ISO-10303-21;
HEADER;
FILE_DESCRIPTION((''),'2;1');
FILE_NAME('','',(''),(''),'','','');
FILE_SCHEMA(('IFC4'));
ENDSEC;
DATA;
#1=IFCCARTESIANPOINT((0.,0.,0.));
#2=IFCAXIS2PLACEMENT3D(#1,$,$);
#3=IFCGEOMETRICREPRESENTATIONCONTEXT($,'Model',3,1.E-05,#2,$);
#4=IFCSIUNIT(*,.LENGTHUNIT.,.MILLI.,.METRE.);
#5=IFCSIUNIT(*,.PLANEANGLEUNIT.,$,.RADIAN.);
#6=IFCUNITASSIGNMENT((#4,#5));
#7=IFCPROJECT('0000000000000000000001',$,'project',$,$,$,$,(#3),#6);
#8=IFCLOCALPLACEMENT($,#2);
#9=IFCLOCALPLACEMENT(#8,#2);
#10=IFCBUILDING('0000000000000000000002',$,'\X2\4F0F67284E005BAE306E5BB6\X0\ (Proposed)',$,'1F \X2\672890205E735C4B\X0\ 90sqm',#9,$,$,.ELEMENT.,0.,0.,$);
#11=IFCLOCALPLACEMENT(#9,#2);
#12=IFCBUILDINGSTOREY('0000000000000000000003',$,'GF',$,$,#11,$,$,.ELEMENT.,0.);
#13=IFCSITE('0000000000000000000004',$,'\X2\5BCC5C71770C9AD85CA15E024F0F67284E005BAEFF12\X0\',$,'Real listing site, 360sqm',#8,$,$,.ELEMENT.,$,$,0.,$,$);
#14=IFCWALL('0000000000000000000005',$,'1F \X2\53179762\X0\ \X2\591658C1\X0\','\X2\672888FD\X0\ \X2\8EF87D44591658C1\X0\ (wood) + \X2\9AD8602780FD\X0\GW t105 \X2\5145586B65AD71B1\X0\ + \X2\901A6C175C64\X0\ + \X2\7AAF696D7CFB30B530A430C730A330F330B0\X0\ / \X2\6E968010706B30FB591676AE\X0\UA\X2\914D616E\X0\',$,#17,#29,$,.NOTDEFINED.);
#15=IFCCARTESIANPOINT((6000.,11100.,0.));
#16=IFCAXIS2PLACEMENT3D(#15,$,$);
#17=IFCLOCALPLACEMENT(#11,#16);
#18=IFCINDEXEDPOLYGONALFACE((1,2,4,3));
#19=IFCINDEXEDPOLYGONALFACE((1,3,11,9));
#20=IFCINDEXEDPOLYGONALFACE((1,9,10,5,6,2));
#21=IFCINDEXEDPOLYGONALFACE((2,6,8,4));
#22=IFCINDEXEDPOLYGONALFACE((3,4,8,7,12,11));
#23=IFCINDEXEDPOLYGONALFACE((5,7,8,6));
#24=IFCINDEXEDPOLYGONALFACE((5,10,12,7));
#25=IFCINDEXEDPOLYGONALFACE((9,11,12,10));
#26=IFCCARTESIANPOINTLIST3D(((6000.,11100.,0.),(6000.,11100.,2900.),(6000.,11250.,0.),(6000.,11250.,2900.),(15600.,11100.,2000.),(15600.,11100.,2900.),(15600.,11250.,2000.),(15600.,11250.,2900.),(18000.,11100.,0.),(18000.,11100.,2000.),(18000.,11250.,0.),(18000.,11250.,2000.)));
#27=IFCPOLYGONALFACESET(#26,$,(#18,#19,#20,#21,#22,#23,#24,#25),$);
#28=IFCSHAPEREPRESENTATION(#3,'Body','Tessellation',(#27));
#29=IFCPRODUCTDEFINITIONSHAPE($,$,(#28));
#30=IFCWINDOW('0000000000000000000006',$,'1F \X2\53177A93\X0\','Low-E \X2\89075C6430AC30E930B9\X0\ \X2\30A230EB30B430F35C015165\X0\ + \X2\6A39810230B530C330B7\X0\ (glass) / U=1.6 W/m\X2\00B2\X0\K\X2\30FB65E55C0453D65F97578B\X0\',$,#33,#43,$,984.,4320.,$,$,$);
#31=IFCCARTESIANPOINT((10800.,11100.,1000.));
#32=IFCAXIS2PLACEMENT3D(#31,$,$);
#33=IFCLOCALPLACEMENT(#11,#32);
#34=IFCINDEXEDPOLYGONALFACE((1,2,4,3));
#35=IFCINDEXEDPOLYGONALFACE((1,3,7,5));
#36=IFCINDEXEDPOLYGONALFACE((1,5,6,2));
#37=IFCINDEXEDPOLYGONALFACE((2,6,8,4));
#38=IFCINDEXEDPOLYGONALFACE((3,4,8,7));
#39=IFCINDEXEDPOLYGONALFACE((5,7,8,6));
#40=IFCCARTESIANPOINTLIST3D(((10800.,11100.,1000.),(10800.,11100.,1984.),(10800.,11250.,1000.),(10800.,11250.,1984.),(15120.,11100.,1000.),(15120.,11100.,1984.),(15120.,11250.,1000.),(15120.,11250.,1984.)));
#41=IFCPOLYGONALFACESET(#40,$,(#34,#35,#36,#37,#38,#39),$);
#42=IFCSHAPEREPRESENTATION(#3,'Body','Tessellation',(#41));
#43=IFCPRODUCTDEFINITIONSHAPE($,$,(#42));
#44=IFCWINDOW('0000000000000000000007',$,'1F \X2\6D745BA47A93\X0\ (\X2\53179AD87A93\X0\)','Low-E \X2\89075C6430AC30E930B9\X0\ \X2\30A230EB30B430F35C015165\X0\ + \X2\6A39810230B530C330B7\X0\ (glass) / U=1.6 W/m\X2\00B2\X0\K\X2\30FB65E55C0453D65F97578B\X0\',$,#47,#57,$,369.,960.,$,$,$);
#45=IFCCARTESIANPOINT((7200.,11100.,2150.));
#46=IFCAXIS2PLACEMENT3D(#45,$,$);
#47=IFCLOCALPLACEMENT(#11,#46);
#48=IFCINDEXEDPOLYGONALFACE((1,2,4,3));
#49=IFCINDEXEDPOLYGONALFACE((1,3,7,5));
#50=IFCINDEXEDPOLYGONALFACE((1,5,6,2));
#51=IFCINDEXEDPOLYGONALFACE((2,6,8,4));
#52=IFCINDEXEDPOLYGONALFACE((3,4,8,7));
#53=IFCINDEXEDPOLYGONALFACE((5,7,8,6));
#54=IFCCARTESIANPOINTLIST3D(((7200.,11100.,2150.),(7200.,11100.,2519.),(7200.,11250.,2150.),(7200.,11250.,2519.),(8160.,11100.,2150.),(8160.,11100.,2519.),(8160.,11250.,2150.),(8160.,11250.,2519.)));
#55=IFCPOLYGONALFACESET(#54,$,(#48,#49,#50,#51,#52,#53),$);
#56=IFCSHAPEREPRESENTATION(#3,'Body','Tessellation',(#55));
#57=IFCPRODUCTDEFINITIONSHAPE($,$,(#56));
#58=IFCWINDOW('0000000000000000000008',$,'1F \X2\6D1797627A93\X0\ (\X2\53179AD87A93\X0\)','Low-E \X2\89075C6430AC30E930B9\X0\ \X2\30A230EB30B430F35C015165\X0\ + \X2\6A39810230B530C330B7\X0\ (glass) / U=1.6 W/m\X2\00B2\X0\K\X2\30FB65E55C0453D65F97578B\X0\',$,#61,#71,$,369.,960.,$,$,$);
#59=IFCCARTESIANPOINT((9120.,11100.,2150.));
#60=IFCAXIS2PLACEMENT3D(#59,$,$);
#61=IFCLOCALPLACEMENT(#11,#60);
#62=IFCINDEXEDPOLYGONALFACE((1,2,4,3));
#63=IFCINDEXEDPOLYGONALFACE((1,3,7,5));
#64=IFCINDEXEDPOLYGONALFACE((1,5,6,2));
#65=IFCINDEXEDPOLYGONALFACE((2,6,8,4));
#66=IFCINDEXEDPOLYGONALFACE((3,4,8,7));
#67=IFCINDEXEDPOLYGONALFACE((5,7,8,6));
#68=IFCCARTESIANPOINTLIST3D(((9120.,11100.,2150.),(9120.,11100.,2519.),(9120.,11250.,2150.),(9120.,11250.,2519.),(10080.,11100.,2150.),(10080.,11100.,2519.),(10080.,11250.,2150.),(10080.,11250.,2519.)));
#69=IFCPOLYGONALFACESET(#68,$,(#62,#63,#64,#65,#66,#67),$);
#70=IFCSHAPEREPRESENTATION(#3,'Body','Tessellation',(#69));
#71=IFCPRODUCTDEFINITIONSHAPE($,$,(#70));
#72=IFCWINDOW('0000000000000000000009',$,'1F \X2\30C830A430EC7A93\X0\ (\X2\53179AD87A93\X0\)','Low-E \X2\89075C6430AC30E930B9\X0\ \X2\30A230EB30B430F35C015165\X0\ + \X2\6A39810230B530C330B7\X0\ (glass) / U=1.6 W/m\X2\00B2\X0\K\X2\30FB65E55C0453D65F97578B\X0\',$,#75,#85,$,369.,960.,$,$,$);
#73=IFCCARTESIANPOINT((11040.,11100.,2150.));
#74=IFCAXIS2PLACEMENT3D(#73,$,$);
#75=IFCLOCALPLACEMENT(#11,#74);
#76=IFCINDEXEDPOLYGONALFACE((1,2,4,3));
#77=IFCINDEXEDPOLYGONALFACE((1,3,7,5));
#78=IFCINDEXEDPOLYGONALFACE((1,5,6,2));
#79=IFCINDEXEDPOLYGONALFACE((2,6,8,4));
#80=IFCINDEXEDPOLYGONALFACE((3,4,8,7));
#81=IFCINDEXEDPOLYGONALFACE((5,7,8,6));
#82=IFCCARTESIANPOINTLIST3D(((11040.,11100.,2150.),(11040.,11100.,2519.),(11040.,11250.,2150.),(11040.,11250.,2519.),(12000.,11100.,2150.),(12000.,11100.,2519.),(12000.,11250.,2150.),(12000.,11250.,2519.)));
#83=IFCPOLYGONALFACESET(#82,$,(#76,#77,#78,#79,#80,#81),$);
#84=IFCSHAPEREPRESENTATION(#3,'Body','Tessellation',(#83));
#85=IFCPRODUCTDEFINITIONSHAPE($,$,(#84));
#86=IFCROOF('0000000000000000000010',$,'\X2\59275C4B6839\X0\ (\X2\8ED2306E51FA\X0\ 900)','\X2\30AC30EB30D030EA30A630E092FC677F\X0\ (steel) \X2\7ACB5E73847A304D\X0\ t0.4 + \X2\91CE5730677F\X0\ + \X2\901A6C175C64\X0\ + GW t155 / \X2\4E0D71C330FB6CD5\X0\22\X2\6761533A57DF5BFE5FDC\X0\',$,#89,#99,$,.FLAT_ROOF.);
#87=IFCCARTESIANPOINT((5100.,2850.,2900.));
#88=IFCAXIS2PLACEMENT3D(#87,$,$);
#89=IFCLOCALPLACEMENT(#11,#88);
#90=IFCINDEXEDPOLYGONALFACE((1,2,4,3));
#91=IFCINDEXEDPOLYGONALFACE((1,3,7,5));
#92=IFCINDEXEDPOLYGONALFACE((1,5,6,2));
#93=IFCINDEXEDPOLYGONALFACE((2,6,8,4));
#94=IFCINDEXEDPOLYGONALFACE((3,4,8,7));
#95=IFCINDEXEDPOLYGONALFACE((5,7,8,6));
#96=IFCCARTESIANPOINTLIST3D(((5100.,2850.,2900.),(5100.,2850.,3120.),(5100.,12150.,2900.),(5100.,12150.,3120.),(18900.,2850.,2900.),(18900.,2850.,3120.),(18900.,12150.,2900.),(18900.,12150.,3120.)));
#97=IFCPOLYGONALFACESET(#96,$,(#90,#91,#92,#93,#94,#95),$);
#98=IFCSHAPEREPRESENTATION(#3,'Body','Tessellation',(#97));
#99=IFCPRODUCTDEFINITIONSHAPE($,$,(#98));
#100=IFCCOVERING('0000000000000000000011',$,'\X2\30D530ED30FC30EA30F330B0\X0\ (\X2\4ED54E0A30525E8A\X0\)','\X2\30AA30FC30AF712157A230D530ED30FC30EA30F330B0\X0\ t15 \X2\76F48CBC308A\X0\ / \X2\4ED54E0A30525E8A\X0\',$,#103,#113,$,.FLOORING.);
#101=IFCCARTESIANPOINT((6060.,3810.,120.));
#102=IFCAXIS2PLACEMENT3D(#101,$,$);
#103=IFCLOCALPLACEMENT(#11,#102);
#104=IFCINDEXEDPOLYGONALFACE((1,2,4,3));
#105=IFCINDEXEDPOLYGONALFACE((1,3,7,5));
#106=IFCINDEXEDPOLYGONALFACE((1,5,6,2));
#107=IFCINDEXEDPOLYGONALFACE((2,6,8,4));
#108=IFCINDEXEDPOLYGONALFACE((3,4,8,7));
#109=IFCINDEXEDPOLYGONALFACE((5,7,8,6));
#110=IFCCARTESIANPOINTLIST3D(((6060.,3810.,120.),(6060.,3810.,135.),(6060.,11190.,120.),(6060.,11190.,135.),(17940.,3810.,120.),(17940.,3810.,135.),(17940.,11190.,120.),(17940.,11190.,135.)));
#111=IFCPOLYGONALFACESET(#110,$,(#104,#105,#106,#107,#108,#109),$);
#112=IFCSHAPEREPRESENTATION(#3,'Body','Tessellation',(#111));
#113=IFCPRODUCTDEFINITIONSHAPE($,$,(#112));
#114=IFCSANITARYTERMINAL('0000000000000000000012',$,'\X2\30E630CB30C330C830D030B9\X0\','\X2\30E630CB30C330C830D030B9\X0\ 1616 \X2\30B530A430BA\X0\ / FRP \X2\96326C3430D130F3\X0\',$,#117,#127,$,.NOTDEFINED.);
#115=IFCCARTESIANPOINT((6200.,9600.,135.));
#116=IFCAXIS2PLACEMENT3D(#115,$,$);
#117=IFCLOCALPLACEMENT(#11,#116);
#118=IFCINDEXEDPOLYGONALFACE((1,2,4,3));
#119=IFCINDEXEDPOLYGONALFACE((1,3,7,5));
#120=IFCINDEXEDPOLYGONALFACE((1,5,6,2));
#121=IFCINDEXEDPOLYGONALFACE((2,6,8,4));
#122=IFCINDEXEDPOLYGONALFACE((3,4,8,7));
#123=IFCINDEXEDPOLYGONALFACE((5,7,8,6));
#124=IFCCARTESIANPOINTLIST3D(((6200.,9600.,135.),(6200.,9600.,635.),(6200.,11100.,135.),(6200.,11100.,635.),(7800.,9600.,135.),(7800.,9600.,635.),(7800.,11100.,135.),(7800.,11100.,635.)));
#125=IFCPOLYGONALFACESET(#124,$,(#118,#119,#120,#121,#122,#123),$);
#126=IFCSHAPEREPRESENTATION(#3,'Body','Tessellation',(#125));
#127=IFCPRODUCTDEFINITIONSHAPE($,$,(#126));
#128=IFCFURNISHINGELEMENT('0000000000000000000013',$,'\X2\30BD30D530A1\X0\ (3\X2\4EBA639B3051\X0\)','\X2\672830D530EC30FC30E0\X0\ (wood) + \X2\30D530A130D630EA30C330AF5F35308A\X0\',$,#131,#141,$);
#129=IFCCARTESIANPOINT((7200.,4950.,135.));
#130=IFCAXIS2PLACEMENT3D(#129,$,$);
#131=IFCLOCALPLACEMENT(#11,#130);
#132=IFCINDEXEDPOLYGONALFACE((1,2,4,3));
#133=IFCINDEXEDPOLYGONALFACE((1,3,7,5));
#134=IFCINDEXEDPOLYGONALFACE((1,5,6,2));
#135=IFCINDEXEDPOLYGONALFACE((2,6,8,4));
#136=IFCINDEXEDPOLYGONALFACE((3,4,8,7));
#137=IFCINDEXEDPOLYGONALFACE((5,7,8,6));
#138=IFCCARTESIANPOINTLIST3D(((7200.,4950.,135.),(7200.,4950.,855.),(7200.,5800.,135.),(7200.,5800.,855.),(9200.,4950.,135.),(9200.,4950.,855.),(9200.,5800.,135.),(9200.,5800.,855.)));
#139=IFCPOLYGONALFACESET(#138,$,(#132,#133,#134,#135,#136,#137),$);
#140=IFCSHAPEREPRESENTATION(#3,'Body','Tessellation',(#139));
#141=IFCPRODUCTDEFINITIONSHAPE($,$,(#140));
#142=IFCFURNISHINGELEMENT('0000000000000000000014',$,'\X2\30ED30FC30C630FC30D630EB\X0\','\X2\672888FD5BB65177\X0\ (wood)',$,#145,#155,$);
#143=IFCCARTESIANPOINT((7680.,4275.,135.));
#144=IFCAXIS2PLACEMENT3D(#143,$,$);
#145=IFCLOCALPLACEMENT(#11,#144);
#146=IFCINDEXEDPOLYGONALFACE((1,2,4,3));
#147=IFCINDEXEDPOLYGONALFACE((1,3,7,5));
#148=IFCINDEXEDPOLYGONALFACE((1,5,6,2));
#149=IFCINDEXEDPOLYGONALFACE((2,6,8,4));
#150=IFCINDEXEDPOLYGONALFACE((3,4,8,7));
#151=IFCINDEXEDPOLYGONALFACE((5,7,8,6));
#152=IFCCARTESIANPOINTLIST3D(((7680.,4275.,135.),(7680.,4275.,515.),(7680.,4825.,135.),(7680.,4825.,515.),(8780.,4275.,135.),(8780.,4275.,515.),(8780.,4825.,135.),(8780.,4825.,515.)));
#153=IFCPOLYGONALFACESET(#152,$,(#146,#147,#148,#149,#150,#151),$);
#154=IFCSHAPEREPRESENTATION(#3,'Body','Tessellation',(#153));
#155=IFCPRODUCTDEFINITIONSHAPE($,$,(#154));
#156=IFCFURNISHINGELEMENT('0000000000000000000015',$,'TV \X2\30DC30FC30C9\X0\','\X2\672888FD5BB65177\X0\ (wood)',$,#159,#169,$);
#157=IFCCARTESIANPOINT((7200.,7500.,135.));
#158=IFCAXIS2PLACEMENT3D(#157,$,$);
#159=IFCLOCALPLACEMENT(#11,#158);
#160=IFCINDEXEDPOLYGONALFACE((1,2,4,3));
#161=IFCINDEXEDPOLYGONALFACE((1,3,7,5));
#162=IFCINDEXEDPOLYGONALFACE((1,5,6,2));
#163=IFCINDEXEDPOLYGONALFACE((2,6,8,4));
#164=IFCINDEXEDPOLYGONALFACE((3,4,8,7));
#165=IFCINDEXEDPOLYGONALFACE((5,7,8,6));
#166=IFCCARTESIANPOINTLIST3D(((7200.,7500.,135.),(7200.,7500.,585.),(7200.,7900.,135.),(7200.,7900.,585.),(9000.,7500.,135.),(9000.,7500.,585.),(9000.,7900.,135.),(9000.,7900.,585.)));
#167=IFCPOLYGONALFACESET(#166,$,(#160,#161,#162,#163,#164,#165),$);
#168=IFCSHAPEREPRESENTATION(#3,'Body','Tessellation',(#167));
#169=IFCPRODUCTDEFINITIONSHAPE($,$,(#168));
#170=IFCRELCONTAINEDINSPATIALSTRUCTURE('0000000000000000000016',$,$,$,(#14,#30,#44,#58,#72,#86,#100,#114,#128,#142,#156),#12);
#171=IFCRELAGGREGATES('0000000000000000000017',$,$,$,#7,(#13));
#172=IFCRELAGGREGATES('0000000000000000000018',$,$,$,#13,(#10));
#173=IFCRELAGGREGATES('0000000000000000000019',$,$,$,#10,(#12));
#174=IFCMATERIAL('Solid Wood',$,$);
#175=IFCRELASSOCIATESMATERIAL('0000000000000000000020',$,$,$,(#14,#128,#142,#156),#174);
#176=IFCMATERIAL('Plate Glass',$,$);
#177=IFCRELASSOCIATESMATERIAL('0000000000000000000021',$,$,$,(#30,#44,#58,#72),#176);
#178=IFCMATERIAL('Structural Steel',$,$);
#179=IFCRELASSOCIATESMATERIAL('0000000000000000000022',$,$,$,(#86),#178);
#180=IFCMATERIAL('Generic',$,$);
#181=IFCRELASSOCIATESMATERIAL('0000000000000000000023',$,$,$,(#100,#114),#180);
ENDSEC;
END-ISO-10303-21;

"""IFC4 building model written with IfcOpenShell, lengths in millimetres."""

from ifc_helpers import new_model, si_unit, frame, frame_2d, origin, place, context, project, spatial, rectangle, extrude, material, element, fill, save


model = new_model("IFC4")

# Units and contexts
model_context = context("Model", 3, precision=1e-05, world=origin())
ifc_project = project(units=[si_unit("LENGTHUNIT", "METRE", prefix="MILLI"), si_unit("PLANEANGLEUNIT", "RADIAN")], contexts=[model_context])

# Site, building, storey
site_placement = place(None, origin())
site = spatial("IfcSite", under=ifc_project, at=site_placement, Name="富山県高岡市伏木一宮２", ObjectType="Real listing site, 360sqm", CompositionType="ELEMENT", RefElevation=0.0)
building_placement = place(site_placement, origin())
building = spatial("IfcBuilding", under=site, at=building_placement, Name="伏木一宮の家 (Proposed)", ObjectType="1F 木造平屋 90sqm", CompositionType="ELEMENT", ElevationOfRefHeight=0.0, ElevationOfTerrain=0.0)
storey_placement = place(building_placement, origin())
storey = spatial("IfcBuildingStorey", under=building, at=storey_placement, Name="GF", CompositionType="ELEMENT", Elevation=0.0)

# Shared definitions
ifc_material_1 = material(Name="Solid Wood")

# Shared definitions
ifc_material_2 = material(Name="Plate Glass")

# Wall, openings, windows
wall_1_placement = place(storey_placement, frame((6000.0, 11100.0, 0.0)))
wall_1 = element("IfcWall", 1, at=wall_1_placement, inside=storey, material=ifc_material_1, Name="1F 北面 外壁", Description="木製 軸組外壁 (wood) + 高性能GW t105 充填断熱 + 通気層 + 窯業系サイディング / 準耐火・外皮UA配慮", PredefinedType="NOTDEFINED", context=model_context, shape_type="SweptSolid", body=[
    extrude(rectangle(XDim=12000.0, YDim=150.0, at=frame_2d((6000.0, 75.0))), frame((6000.0, 11100.0, 0.0)), (0.0, 0.0, 1.0), 2900.0),
])
opening_1_placement = place(storey_placement, frame((10800.0, 11100.0, 1000.0)))
opening_1 = element("IfcOpeningElement", 2, at=opening_1_placement, cuts=wall_1, PredefinedType="NOTDEFINED", context=model_context, shape_type="SweptSolid", body=[
    extrude(rectangle(XDim=4320.0, YDim=150.0, at=frame_2d((2160.0, 75.0))), frame((10800.0, 11100.0, 1000.0)), (0.0, 0.0, 1.0), 984.0),
])
opening_2_placement = place(storey_placement, frame((7200.0, 11100.0, 2150.0)))
opening_2 = element("IfcOpeningElement", 3, at=opening_2_placement, cuts=wall_1, PredefinedType="NOTDEFINED", context=model_context, shape_type="SweptSolid", body=[
    extrude(rectangle(XDim=960.0, YDim=150.0, at=frame_2d((480.0, 75.0))), frame((7200.0, 11100.0, 2150.0)), (0.0, 0.0, 1.0), 369.0),
])
opening_3_placement = place(storey_placement, frame((9120.0, 11100.0, 2150.0)))
opening_3 = element("IfcOpeningElement", 4, at=opening_3_placement, cuts=wall_1, PredefinedType="NOTDEFINED", context=model_context, shape_type="SweptSolid", body=[
    extrude(rectangle(XDim=960.0, YDim=150.0, at=frame_2d((480.0, 75.0))), frame((9120.0, 11100.0, 2150.0)), (0.0, 0.0, 1.0), 369.0),
])
opening_4_placement = place(storey_placement, frame((11040.0, 11100.0, 2150.0)))
opening_4 = element("IfcOpeningElement", 5, at=opening_4_placement, cuts=wall_1, PredefinedType="NOTDEFINED", context=model_context, shape_type="SweptSolid", body=[
    extrude(rectangle(XDim=960.0, YDim=150.0, at=frame_2d((480.0, 75.0))), frame((11040.0, 11100.0, 2150.0)), (0.0, 0.0, 1.0), 369.0),
])
window_1_placement = place(storey_placement, frame((10800.0, 11100.0, 1000.0)))
window_1 = element("IfcWindow", 6, at=window_1_placement, inside=storey, material=ifc_material_2, Name="1F 北窓", Description="Low-E 複層ガラス アルゴン封入 + 樹脂サッシ (glass) / U=1.6 W/m²K・日射取得型", OverallHeight=984.0, OverallWidth=4320.0, context=model_context, shape_type="SweptSolid", body=[
    extrude(rectangle(XDim=4320.0, YDim=150.0, at=frame_2d((2160.0, 75.0))), frame((10800.0, 11100.0, 1000.0)), (0.0, 0.0, 1.0), 984.0),
])
fill(opening_1, window_1)
window_2_placement = place(storey_placement, frame((7200.0, 11100.0, 2150.0)))
window_2 = element("IfcWindow", 7, at=window_2_placement, inside=storey, material=ifc_material_2, Name="1F 浴室窓 (北高窓)", Description="Low-E 複層ガラス アルゴン封入 + 樹脂サッシ (glass) / U=1.6 W/m²K・日射取得型", OverallHeight=369.0, OverallWidth=960.0, context=model_context, shape_type="SweptSolid", body=[
    extrude(rectangle(XDim=960.0, YDim=150.0, at=frame_2d((480.0, 75.0))), frame((7200.0, 11100.0, 2150.0)), (0.0, 0.0, 1.0), 369.0),
])
fill(opening_2, window_2)
window_3_placement = place(storey_placement, frame((9120.0, 11100.0, 2150.0)))
window_3 = element("IfcWindow", 8, at=window_3_placement, inside=storey, material=ifc_material_2, Name="1F 洗面窓 (北高窓)", Description="Low-E 複層ガラス アルゴン封入 + 樹脂サッシ (glass) / U=1.6 W/m²K・日射取得型", OverallHeight=369.0, OverallWidth=960.0, context=model_context, shape_type="SweptSolid", body=[
    extrude(rectangle(XDim=960.0, YDim=150.0, at=frame_2d((480.0, 75.0))), frame((9120.0, 11100.0, 2150.0)), (0.0, 0.0, 1.0), 369.0),
])
fill(opening_3, window_3)
window_4_placement = place(storey_placement, frame((11040.0, 11100.0, 2150.0)))
window_4 = element("IfcWindow", 9, at=window_4_placement, inside=storey, material=ifc_material_2, Name="1F トイレ窓 (北高窓)", Description="Low-E 複層ガラス アルゴン封入 + 樹脂サッシ (glass) / U=1.6 W/m²K・日射取得型", OverallHeight=369.0, OverallWidth=960.0, context=model_context, shape_type="SweptSolid", body=[
    extrude(rectangle(XDim=960.0, YDim=150.0, at=frame_2d((480.0, 75.0))), frame((11040.0, 11100.0, 2150.0)), (0.0, 0.0, 1.0), 369.0),
])
fill(opening_4, window_4)

# Roof
ifc_material_3 = material(Name="Structural Steel")
roof_placement = place(storey_placement, frame((5100.0, 2850.0, 2900.0)))
element("IfcRoof", 10, at=roof_placement, inside=storey, material=ifc_material_3, Name="大屋根 (軒の出 900)", Description="ガルバリウム鋼板 (steel) 立平葺き t0.4 + 野地板 + 通気層 + GW t155 / 不燃・法22条区域対応", PredefinedType="FLAT_ROOF", context=model_context, shape_type="SweptSolid", body=[
    extrude(rectangle(XDim=13800.0, YDim=9300.0, at=frame_2d((6900.0, 4650.0))), frame((5100.0, 2850.0, 2900.0)), (0.0, 0.0, 1.0), 220.0),
])

# Covering
ifc_material_4 = material(Name="Generic")
covering_placement = place(storey_placement, frame((6060.0, 3810.0, 120.0)))
element("IfcCovering", 11, at=covering_placement, inside=storey, material=ifc_material_4, Name="フローリング (仕上げ床)", Description="オーク無垢フローリング t15 直貼り / 仕上げ床", PredefinedType="FLOORING", context=model_context, shape_type="SweptSolid", body=[
    extrude(rectangle(XDim=11880.0, YDim=7380.0, at=frame_2d((5940.0, 3690.0))), frame((6060.0, 3810.0, 120.0)), (0.0, 0.0, 1.0), 15.0),
])

# Sanitary terminal
sanitary_terminal_placement = place(storey_placement, frame((6200.0, 9600.0, 135.0)))
element("IfcSanitaryTerminal", 12, at=sanitary_terminal_placement, inside=storey, material=ifc_material_4, Name="ユニットバス", Description="ユニットバス 1616 サイズ / FRP 防水パン", PredefinedType="NOTDEFINED", context=model_context, shape_type="SweptSolid", body=[
    extrude(rectangle(XDim=1600.0, YDim=1500.0, at=frame_2d((800.0, 750.0))), frame((6200.0, 9600.0, 135.0)), (0.0, 0.0, 1.0), 500.0),
])

# Furnishing elements
furnishing_1_placement = place(storey_placement, frame((7200.0, 4950.0, 135.0)))
element("IfcFurnishingElement", 13, at=furnishing_1_placement, inside=storey, material=ifc_material_1, Name="ソファ (3人掛け)", Description="木フレーム (wood) + ファブリック張り", context=model_context, shape_type="SweptSolid", body=[
    extrude(rectangle(XDim=2000.0, YDim=850.0, at=frame_2d((1000.0, 425.0))), frame((7200.0, 4950.0, 135.0)), (0.0, 0.0, 1.0), 720.0),
])
furnishing_2_placement = place(storey_placement, frame((7680.0, 4275.0, 135.0)))
element("IfcFurnishingElement", 14, at=furnishing_2_placement, inside=storey, material=ifc_material_1, Name="ローテーブル", Description="木製家具 (wood)", context=model_context, shape_type="SweptSolid", body=[
    extrude(rectangle(XDim=1100.0, YDim=550.0, at=frame_2d((550.0, 275.0))), frame((7680.0, 4275.0, 135.0)), (0.0, 0.0, 1.0), 380.0),
])
furnishing_3_placement = place(storey_placement, frame((7200.0, 7500.0, 135.0)))
element("IfcFurnishingElement", 15, at=furnishing_3_placement, inside=storey, material=ifc_material_1, Name="TV ボード", Description="木製家具 (wood)", context=model_context, shape_type="SweptSolid", body=[
    extrude(rectangle(XDim=1800.0, YDim=400.0, at=frame_2d((900.0, 200.0))), frame((7200.0, 7500.0, 135.0)), (0.0, 0.0, 1.0), 450.0),
])

save(model, "model.ifc")
